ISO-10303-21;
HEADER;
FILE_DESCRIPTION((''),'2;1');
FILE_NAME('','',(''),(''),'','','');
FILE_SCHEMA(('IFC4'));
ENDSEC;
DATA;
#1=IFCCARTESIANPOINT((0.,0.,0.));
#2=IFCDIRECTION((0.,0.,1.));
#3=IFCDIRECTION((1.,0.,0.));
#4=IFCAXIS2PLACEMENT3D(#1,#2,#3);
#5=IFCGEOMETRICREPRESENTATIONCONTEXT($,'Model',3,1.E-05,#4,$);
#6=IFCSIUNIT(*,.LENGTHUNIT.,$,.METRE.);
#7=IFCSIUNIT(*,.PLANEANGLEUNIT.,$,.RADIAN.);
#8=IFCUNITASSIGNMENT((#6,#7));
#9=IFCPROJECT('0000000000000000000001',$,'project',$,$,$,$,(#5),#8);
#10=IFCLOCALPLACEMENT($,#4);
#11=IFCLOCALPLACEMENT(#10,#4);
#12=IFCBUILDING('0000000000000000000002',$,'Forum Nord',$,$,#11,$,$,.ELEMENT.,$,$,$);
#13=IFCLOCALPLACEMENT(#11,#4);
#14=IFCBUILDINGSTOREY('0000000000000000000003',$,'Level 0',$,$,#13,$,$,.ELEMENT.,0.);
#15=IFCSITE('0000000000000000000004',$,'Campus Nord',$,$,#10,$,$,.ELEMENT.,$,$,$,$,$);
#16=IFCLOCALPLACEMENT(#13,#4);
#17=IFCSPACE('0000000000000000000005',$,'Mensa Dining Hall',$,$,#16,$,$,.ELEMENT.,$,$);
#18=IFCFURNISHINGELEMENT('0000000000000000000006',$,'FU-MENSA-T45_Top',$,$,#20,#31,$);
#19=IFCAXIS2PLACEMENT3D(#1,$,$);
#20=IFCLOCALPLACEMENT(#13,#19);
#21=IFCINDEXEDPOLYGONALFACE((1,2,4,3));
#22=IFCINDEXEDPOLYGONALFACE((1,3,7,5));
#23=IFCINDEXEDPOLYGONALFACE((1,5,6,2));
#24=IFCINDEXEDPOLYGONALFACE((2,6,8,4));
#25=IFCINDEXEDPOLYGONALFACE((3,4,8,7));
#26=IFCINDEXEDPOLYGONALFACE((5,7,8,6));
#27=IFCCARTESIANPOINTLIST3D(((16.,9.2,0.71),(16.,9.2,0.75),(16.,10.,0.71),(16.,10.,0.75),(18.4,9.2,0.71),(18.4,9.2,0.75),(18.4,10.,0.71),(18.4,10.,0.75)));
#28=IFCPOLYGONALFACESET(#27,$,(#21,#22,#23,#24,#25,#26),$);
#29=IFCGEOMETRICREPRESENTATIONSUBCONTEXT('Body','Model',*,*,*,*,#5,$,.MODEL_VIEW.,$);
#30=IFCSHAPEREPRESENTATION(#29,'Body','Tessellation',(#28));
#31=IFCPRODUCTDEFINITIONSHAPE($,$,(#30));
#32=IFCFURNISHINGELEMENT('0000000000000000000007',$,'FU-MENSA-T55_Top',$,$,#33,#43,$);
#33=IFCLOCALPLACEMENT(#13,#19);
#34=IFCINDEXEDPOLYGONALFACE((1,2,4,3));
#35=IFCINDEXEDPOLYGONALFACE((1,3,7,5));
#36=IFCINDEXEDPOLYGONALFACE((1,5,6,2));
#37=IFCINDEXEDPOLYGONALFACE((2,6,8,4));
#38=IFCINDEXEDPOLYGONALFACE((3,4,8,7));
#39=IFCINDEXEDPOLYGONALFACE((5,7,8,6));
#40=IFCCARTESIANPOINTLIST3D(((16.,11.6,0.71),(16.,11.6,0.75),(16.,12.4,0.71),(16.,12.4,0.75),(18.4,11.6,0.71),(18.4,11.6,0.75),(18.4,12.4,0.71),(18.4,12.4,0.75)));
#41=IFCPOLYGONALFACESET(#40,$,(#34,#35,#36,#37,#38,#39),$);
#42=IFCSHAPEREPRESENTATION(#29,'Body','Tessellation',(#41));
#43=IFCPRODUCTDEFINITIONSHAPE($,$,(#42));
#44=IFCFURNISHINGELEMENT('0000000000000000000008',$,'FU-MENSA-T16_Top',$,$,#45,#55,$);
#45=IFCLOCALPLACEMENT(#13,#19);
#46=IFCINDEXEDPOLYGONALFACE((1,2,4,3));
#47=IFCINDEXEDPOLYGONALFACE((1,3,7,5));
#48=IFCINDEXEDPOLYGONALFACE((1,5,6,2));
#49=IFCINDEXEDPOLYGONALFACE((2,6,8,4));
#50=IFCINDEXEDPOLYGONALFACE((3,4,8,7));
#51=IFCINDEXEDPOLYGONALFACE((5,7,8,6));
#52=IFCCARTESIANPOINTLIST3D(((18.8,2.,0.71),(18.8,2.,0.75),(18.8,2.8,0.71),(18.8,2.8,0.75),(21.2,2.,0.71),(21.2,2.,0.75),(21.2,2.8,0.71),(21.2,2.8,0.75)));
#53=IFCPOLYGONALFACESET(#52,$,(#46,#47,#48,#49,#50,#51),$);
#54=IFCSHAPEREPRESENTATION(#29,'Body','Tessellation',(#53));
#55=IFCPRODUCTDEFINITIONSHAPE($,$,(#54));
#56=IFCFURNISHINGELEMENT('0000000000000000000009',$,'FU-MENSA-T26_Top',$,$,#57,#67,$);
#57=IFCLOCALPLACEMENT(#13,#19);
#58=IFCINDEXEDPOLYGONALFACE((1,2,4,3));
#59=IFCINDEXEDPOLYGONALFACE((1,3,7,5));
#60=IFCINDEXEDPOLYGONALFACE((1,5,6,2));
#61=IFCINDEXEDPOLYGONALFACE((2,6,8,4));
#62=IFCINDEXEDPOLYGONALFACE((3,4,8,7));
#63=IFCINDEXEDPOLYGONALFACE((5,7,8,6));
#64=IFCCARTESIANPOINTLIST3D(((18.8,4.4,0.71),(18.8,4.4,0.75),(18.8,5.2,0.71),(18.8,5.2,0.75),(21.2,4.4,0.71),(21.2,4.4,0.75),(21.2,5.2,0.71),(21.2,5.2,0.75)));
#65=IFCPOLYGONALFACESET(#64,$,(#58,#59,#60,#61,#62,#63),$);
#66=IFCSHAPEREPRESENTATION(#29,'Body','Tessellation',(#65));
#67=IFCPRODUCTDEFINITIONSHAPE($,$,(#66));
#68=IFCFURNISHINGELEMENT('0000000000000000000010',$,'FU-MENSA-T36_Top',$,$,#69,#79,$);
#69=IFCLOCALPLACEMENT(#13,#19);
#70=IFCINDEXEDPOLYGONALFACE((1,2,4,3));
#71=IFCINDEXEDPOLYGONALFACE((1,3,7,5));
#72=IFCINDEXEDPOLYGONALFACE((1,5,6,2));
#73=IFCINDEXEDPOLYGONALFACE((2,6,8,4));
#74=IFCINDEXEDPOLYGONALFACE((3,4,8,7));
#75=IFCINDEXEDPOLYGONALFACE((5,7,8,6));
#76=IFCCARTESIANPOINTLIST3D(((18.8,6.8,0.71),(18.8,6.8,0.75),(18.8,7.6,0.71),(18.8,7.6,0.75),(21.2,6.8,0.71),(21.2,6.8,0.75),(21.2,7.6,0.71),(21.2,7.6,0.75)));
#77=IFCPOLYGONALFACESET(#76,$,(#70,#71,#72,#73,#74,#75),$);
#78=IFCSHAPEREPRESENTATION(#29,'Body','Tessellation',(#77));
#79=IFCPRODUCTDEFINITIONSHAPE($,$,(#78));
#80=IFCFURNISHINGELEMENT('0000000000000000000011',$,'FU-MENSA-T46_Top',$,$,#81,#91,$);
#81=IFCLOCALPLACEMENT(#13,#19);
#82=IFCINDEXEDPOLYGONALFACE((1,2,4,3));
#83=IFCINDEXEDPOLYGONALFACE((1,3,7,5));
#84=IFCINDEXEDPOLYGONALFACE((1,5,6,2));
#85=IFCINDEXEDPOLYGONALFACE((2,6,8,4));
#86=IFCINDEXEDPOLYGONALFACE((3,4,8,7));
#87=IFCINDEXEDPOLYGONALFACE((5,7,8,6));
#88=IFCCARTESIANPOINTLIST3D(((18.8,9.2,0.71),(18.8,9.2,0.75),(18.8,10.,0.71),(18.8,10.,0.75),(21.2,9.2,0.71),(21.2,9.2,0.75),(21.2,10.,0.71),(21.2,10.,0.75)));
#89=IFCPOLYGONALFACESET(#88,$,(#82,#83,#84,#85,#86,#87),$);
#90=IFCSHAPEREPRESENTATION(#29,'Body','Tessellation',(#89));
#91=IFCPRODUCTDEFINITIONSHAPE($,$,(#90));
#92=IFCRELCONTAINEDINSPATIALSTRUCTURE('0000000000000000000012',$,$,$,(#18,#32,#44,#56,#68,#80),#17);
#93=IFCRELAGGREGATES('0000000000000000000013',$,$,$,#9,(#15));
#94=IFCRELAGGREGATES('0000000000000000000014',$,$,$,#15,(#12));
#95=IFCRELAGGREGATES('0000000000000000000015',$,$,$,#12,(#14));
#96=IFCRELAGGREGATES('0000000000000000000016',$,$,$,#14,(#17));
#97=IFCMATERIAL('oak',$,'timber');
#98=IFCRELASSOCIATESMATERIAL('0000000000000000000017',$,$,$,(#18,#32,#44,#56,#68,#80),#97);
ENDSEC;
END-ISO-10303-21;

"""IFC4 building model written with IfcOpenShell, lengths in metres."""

from ifc_helpers import new_model, si_unit, frame, frame_2d, origin_with_axes, place, context, subcontext, project, spatial, rectangle, extrude, material, element, save


model = new_model("IFC4")

# Units and contexts
model_context = context("Model", 3, precision=1e-05, world=origin_with_axes())
body_context = subcontext(model_context, "Body", "Model", "MODEL_VIEW")
ifc_project = project(units=[si_unit("LENGTHUNIT", "METRE"), si_unit("PLANEANGLEUNIT", "RADIAN")], contexts=[model_context])

# Site, building, storey, space
site_placement = place(None, origin_with_axes())
site = spatial("IfcSite", under=ifc_project, at=site_placement, Name="Campus Nord", CompositionType="ELEMENT")
building_placement = place(site_placement, origin_with_axes())
building = spatial("IfcBuilding", under=site, at=building_placement, Name="Forum Nord", CompositionType="ELEMENT")
storey_placement = place(building_placement, origin_with_axes())
storey = spatial("IfcBuildingStorey", under=building, at=storey_placement, Name="Level 0", CompositionType="ELEMENT", Elevation=0.0)
space_placement = place(storey_placement, origin_with_axes())
space = spatial("IfcSpace", under=storey, at=space_placement, Name="Mensa Dining Hall", CompositionType="ELEMENT")

# Furnishing elements
ifc_material_1 = material(Name="oak", Category="timber")
furnishing_1_placement = place(storey_placement, frame((16.0, 9.2, 0.0), z_axis=(0.0, 0.0, 1.0), x_axis=(1.0, 0.0, 0.0)))
element("IfcFurnishingElement", 1, at=furnishing_1_placement, inside=space, material=ifc_material_1, Name="FU-MENSA-T45_Top", context=body_context, shape_type="SweptSolid", body=[
    extrude(rectangle(XDim=2.4, YDim=0.8, at=frame_2d((1.2, 0.4), x_axis=(1.0, 0.0))), frame((0.0, 0.0, 0.71), z_axis=(0.0, 0.0, 1.0), x_axis=(1.0, 0.0, 0.0)), (0.0, 0.0, 1.0), 0.04),
])
furnishing_2_placement = place(storey_placement, frame((16.0, 11.6, 0.0), z_axis=(0.0, 0.0, 1.0), x_axis=(1.0, 0.0, 0.0)))
element("IfcFurnishingElement", 2, at=furnishing_2_placement, inside=space, material=ifc_material_1, Name="FU-MENSA-T55_Top", context=body_context, shape_type="SweptSolid", body=[
    extrude(rectangle(XDim=2.4, YDim=0.8, at=frame_2d((1.2, 0.4), x_axis=(1.0, 0.0))), frame((0.0, 0.0, 0.71), z_axis=(0.0, 0.0, 1.0), x_axis=(1.0, 0.0, 0.0)), (0.0, 0.0, 1.0), 0.04),
])
furnishing_3_placement = place(storey_placement, frame((18.8, 2.0, 0.0), z_axis=(0.0, 0.0, 1.0), x_axis=(1.0, 0.0, 0.0)))
element("IfcFurnishingElement", 3, at=furnishing_3_placement, inside=space, material=ifc_material_1, Name="FU-MENSA-T16_Top", context=body_context, shape_type="SweptSolid", body=[
    extrude(rectangle(XDim=2.4, YDim=0.8, at=frame_2d((1.2, 0.4), x_axis=(1.0, 0.0))), frame((0.0, 0.0, 0.71), z_axis=(0.0, 0.0, 1.0), x_axis=(1.0, 0.0, 0.0)), (0.0, 0.0, 1.0), 0.04),
])
furnishing_4_placement = place(storey_placement, frame((18.8, 4.4, 0.0), z_axis=(0.0, 0.0, 1.0), x_axis=(1.0, 0.0, 0.0)))
element("IfcFurnishingElement", 4, at=furnishing_4_placement, inside=space, material=ifc_material_1, Name="FU-MENSA-T26_Top", context=body_context, shape_type="SweptSolid", body=[
    extrude(rectangle(XDim=2.4, YDim=0.8, at=frame_2d((1.2, 0.4), x_axis=(1.0, 0.0))), frame((0.0, 0.0, 0.71), z_axis=(0.0, 0.0, 1.0), x_axis=(1.0, 0.0, 0.0)), (0.0, 0.0, 1.0), 0.04),
])
furnishing_5_placement = place(storey_placement, frame((18.8, 6.8, 0.0), z_axis=(0.0, 0.0, 1.0), x_axis=(1.0, 0.0, 0.0)))
element("IfcFurnishingElement", 5, at=furnishing_5_placement, inside=space, material=ifc_material_1, Name="FU-MENSA-T36_Top", context=body_context, shape_type="SweptSolid", body=[
    extrude(rectangle(XDim=2.4, YDim=0.8, at=frame_2d((1.2, 0.4), x_axis=(1.0, 0.0))), frame((0.0, 0.0, 0.71), z_axis=(0.0, 0.0, 1.0), x_axis=(1.0, 0.0, 0.0)), (0.0, 0.0, 1.0), 0.04),
])
furnishing_6_placement = place(storey_placement, frame((18.8, 9.2, 0.0), z_axis=(0.0, 0.0, 1.0), x_axis=(1.0, 0.0, 0.0)))
element("IfcFurnishingElement", 6, at=furnishing_6_placement, inside=space, material=ifc_material_1, Name="FU-MENSA-T46_Top", context=body_context, shape_type="SweptSolid", body=[
    extrude(rectangle(XDim=2.4, YDim=0.8, at=frame_2d((1.2, 0.4), x_axis=(1.0, 0.0))), frame((0.0, 0.0, 0.71), z_axis=(0.0, 0.0, 1.0), x_axis=(1.0, 0.0, 0.0)), (0.0, 0.0, 1.0), 0.04),
])

save(model, "model.ifc")
